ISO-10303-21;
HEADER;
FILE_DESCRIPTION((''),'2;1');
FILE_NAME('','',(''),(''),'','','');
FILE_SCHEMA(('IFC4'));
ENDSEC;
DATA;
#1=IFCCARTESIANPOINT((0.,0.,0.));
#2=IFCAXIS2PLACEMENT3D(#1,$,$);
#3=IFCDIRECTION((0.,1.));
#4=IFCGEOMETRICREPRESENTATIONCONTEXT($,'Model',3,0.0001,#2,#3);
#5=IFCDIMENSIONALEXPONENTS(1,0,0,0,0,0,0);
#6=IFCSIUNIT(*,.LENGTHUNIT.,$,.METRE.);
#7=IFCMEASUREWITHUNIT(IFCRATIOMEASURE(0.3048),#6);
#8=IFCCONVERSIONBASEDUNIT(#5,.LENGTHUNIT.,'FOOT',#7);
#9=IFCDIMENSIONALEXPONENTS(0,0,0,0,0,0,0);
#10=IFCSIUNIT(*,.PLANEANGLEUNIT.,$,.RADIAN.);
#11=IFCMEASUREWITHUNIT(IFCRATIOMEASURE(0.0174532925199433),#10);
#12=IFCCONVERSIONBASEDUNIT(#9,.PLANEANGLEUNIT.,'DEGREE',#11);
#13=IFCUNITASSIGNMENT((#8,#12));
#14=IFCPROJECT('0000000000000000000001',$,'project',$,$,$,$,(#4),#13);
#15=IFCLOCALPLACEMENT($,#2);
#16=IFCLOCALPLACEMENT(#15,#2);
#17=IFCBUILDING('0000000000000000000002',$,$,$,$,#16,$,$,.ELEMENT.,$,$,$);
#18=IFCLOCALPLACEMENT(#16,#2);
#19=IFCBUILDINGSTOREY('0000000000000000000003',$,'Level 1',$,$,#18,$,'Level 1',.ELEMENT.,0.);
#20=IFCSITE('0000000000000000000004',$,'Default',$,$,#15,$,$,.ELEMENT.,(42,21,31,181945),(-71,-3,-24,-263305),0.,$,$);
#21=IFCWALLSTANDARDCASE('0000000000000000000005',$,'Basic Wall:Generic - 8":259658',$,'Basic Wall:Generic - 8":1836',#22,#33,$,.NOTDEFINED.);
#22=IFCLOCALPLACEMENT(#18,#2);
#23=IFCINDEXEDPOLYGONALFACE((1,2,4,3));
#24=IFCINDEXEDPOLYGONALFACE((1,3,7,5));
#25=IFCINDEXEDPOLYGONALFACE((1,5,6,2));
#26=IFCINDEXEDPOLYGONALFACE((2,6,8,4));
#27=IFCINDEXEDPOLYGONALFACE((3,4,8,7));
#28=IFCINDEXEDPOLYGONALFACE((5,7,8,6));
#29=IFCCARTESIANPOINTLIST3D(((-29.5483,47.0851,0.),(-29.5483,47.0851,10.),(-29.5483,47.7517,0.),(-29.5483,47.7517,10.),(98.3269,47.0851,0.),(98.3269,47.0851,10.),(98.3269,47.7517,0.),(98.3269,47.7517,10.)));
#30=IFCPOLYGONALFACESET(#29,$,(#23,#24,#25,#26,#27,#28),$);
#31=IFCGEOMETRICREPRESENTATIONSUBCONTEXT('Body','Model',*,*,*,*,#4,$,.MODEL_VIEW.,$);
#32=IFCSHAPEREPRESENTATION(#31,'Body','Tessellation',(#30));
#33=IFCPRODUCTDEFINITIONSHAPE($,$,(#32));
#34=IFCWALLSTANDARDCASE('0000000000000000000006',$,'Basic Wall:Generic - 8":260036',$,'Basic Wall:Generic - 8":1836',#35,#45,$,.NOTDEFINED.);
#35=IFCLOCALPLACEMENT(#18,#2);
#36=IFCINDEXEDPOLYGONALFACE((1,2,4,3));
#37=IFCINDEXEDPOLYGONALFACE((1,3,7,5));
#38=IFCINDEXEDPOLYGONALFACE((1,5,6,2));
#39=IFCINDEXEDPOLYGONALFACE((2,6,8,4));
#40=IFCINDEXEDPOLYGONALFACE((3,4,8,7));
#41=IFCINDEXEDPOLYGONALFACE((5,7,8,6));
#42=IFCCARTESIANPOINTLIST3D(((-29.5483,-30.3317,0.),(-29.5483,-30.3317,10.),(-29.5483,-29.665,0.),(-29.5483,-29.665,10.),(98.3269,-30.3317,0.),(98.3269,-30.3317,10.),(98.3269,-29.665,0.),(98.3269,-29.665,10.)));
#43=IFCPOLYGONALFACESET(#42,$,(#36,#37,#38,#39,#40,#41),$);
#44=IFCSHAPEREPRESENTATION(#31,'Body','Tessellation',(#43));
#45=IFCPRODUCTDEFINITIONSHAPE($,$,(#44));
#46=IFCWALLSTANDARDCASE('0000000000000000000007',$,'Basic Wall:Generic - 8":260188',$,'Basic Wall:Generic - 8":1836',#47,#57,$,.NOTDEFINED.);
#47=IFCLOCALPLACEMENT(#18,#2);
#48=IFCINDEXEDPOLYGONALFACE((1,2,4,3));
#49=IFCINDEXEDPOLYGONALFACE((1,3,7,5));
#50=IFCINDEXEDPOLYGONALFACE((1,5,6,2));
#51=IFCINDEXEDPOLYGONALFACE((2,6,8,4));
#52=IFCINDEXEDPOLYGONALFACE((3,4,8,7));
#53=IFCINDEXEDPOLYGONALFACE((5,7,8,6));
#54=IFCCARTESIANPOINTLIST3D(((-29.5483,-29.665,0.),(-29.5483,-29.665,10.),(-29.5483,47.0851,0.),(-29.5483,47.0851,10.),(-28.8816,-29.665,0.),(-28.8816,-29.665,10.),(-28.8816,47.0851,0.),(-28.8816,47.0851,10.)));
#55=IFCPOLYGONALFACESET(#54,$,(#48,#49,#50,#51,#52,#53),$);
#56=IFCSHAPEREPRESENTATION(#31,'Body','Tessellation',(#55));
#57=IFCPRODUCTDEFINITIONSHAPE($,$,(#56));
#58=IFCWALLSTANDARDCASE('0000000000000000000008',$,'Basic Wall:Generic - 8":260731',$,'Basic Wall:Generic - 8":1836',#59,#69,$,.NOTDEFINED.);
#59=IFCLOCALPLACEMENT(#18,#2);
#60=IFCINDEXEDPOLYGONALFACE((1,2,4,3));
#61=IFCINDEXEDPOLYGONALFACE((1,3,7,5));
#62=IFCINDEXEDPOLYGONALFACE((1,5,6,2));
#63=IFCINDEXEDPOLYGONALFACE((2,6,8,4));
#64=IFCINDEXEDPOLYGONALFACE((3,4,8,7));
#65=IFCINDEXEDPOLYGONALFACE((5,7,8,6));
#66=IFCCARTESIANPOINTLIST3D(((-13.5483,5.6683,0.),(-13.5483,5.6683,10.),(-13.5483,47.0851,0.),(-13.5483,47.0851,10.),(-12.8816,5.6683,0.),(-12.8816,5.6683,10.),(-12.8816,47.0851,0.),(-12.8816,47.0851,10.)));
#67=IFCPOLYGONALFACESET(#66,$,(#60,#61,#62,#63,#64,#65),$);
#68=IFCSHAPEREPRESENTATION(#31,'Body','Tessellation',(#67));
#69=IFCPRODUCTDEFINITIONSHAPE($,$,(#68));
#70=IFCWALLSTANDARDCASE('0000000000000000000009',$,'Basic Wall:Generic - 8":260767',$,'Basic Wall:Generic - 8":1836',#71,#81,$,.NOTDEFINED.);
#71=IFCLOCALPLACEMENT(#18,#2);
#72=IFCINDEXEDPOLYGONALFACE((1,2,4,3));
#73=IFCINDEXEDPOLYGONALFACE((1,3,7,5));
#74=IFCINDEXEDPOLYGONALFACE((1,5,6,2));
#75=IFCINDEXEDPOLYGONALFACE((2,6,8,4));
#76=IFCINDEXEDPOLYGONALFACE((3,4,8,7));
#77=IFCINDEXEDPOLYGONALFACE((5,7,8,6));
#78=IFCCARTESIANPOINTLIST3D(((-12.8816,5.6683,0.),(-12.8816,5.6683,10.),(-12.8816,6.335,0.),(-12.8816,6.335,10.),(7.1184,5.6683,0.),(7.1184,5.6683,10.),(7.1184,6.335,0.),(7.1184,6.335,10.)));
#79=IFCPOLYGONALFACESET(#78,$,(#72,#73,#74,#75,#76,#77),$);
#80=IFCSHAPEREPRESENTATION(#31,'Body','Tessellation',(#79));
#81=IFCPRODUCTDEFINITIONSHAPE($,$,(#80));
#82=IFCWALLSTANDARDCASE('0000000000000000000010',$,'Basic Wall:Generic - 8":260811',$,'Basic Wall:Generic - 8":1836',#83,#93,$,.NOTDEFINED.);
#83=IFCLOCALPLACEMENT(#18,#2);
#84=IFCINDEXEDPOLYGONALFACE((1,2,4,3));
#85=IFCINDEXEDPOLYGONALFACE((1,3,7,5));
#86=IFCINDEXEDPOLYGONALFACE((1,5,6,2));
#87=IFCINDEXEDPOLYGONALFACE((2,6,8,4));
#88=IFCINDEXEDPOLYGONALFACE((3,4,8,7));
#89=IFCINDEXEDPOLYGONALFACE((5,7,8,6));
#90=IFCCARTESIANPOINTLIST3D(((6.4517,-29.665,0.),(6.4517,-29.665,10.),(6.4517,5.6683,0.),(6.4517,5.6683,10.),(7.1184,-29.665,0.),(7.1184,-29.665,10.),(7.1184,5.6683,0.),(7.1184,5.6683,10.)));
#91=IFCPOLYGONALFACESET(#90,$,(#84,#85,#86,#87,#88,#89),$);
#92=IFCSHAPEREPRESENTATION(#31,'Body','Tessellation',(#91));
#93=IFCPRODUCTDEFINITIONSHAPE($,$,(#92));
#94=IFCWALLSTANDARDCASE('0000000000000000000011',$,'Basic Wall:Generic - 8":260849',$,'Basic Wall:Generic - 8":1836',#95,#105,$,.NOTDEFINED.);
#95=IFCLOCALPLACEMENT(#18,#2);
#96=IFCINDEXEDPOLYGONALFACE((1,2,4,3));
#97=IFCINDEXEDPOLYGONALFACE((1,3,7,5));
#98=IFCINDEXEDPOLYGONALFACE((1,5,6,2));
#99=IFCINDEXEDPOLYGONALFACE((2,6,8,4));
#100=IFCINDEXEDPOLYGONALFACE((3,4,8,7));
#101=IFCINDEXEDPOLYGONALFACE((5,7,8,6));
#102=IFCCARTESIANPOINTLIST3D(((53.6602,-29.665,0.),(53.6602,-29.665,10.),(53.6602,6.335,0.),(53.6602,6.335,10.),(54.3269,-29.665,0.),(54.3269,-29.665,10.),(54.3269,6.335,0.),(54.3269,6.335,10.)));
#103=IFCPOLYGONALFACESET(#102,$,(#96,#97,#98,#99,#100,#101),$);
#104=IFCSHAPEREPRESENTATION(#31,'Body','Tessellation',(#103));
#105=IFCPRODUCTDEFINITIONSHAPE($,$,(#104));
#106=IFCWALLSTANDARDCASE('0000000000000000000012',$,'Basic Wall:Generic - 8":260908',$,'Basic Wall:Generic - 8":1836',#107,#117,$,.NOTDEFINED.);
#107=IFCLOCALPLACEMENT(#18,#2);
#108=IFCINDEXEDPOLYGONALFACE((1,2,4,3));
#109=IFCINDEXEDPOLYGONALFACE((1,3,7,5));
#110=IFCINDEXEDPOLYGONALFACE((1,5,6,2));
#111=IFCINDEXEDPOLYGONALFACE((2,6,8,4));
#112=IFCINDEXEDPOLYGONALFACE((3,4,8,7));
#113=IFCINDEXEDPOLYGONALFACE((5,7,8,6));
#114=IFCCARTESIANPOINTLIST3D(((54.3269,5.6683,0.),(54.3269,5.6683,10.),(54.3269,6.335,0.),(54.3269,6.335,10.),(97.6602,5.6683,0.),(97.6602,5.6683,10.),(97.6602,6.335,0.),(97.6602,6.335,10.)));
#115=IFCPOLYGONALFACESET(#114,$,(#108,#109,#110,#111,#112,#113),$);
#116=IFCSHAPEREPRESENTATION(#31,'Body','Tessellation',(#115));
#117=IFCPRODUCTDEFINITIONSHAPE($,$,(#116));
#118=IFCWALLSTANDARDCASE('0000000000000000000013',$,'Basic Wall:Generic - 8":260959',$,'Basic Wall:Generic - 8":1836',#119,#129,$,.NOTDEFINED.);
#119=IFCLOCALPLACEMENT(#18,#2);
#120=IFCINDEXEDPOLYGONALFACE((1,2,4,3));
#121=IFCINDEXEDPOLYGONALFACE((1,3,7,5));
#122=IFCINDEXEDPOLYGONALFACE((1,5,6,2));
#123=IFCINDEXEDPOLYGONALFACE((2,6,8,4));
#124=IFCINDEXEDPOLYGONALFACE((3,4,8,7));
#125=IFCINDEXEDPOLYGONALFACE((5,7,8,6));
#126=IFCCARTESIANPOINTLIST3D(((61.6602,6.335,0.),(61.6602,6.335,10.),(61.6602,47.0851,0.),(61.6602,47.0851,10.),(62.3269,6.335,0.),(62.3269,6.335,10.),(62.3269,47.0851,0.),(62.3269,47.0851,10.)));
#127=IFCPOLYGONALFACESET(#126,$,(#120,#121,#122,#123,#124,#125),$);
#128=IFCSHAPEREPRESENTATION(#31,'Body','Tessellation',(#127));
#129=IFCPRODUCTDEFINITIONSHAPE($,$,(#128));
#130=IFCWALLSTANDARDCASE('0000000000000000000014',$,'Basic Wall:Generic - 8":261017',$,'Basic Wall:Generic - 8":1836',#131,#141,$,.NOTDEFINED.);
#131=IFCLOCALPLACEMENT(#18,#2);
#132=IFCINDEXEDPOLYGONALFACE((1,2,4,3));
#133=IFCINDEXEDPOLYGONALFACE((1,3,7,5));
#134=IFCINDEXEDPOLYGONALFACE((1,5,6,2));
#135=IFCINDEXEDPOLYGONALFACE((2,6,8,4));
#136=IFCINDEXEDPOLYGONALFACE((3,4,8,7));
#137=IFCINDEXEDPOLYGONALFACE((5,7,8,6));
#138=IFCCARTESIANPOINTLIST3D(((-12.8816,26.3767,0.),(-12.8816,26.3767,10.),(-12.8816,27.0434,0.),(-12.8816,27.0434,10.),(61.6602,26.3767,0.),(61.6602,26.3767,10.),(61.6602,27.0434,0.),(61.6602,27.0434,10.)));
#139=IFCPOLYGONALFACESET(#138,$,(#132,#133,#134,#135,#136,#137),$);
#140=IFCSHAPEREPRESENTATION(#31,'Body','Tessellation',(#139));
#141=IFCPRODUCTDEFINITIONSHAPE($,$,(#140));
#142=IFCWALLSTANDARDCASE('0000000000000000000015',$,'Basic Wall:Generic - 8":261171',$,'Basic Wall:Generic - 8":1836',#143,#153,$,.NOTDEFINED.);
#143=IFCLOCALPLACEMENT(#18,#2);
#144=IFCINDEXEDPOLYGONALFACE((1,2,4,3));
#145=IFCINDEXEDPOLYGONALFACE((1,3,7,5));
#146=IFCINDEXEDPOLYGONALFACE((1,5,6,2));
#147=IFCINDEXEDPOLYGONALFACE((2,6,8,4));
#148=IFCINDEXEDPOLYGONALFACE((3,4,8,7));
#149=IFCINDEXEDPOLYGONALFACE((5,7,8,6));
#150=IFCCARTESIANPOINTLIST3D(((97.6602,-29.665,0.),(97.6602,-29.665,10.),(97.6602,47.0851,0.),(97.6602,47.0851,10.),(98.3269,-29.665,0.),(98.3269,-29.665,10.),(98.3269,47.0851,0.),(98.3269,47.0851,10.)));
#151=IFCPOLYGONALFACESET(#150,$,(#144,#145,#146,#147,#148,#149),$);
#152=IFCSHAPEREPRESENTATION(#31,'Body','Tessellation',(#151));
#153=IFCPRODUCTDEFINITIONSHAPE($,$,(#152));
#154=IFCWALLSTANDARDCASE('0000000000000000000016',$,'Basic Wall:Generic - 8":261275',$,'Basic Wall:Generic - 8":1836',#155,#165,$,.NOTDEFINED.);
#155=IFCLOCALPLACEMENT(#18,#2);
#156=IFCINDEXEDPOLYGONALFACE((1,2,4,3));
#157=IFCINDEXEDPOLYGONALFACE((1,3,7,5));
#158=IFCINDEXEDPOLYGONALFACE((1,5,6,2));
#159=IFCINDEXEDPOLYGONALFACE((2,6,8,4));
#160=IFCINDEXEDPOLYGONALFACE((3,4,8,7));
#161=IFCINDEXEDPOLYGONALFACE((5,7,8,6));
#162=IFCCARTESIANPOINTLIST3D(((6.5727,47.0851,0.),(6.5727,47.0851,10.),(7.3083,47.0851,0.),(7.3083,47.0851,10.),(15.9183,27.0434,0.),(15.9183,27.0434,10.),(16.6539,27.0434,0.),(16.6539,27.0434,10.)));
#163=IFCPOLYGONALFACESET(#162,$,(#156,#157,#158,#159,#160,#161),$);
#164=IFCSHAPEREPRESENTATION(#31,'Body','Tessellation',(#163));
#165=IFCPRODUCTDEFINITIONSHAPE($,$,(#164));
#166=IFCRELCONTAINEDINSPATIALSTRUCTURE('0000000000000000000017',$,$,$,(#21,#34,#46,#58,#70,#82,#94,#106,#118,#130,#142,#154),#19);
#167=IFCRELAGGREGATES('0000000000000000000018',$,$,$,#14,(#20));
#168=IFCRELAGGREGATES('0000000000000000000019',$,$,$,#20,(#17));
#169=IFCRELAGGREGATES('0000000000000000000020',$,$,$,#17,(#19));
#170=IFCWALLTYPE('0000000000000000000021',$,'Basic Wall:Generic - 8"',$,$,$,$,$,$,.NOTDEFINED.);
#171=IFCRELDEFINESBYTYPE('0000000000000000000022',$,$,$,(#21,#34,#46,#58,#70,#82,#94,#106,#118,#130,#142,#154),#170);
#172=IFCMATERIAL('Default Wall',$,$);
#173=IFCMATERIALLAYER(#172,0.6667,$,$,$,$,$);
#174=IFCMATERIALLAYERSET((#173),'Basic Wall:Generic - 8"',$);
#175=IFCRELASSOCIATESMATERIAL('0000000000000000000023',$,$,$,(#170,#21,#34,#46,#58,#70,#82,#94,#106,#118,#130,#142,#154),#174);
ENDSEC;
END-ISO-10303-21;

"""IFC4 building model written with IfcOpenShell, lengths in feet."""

from ifc_helpers import new_model, entity, si_unit, converted_unit, direction, frame, frame_2d, origin, place, context, subcontext, project, spatial, polyline, rectangle, outline, extrude, material, layer, layer_set, layer_usage, type_object, element, save


model = new_model("IFC4")

# Units and contexts
model_context = context("Model", 3, precision=0.0001, world=origin(), true_north=direction((0.0, 1.0)))
body_context = subcontext(model_context, "Body", "Model", "MODEL_VIEW")
ifc_project = project(units=[converted_unit("LENGTHUNIT", "FOOT", entity("IfcRatioMeasure", 0.3048), si_unit("LENGTHUNIT", "METRE"), dimensions=[1, 0, 0, 0, 0, 0, 0]), converted_unit("PLANEANGLEUNIT", "DEGREE", entity("IfcRatioMeasure", 0.0174532925199433), si_unit("PLANEANGLEUNIT", "RADIAN"), dimensions=[0, 0, 0, 0, 0, 0, 0])], contexts=[model_context])

# Site, building, storey
site_placement = place(None, origin())
site = spatial("IfcSite", under=ifc_project, at=site_placement, Name="Default", CompositionType="ELEMENT", RefLatitude=(42, 21, 31, 181945), RefLongitude=(-71, -3, -24, -263305), RefElevation=0.0)
building_placement = place(site_placement, origin())
building = spatial("IfcBuilding", under=site, at=building_placement, CompositionType="ELEMENT")
storey_placement = place(building_placement, origin())
storey = spatial("IfcBuildingStorey", under=building, at=storey_placement, Name="Level 1", LongName="Level 1", CompositionType="ELEMENT", Elevation=0.0)

# Walls
ifc_material = material(Name="Default Wall")
ifc_layer = layer(ifc_material, 0.6667)
ifc_layer_set = layer_set([ifc_layer], Name="Basic Wall:Generic - 8\"")
ifc_layer_usage_1 = layer_usage(ifc_layer_set, "AXIS2", "NEGATIVE", 0.3333)
wall_type = type_object("IfcWallType", Name="Basic Wall:Generic - 8\"", PredefinedType="NOTDEFINED", material=ifc_layer_set)
wall_1_placement = place(storey_placement, frame((-29.5483, 47.4184, 0.0)))
element("IfcWallStandardCase", 1, at=wall_1_placement, inside=storey, type_object=wall_type, material=ifc_layer_usage_1, Name="Basic Wall:Generic - 8\":259658", ObjectType="Basic Wall:Generic - 8\":1836", PredefinedType="NOTDEFINED", context=body_context, shape_type="SweptSolid", body=[
    extrude(rectangle(XDim=127.8752, YDim=0.6667, at=frame_2d((63.9376, 0.0), x_axis=(-1.0, 0.0))), origin(), (0.0, 0.0, 1.0), 10.0),
])
ifc_layer_usage_2 = layer_usage(ifc_layer_set, "AXIS2", "NEGATIVE", 0.3333)
wall_2_placement = place(storey_placement, frame((98.3269, -29.9983, 0.0), z_axis=(0.0, 0.0, 1.0), x_axis=(-1.0, 0.0, 0.0)))
element("IfcWallStandardCase", 2, at=wall_2_placement, inside=storey, type_object=wall_type, material=ifc_layer_usage_2, Name="Basic Wall:Generic - 8\":260036", ObjectType="Basic Wall:Generic - 8\":1836", PredefinedType="NOTDEFINED", context=body_context, shape_type="SweptSolid", body=[
    extrude(rectangle(XDim=127.8752, YDim=0.6667, at=frame_2d((63.9376, 0.0), x_axis=(-1.0, 0.0))), origin(), (0.0, 0.0, 1.0), 10.0),
])
ifc_layer_usage_3 = layer_usage(ifc_layer_set, "AXIS2", "NEGATIVE", 0.3333)
wall_3_placement = place(storey_placement, frame((-29.215, 47.0851, 0.0), z_axis=(0.0, 0.0, 1.0), x_axis=(0.0, -1.0, 0.0)))
element("IfcWallStandardCase", 3, at=wall_3_placement, inside=storey, type_object=wall_type, material=ifc_layer_usage_3, Name="Basic Wall:Generic - 8\":260188", ObjectType="Basic Wall:Generic - 8\":1836", PredefinedType="NOTDEFINED", context=body_context, shape_type="SweptSolid", body=[
    extrude(rectangle(XDim=76.7501, YDim=0.6667, at=frame_2d((38.375, 0.0), x_axis=(-1.0, 0.0))), origin(), (0.0, 0.0, 1.0), 10.0),
])
ifc_layer_usage_4 = layer_usage(ifc_layer_set, "AXIS2", "NEGATIVE", 0.3333)
wall_4_placement = place(storey_placement, frame((-13.215, 47.0851, 0.0), z_axis=(0.0, 0.0, 1.0), x_axis=(0.0, -1.0, 0.0)))
element("IfcWallStandardCase", 4, at=wall_4_placement, inside=storey, type_object=wall_type, material=ifc_layer_usage_4, Name="Basic Wall:Generic - 8\":260731", ObjectType="Basic Wall:Generic - 8\":1836", PredefinedType="NOTDEFINED", context=body_context, shape_type="SweptSolid", body=[
    extrude(rectangle(XDim=41.4167, YDim=0.6667, at=frame_2d((20.7084, 0.0), x_axis=(-1.0, 0.0))), origin(), (0.0, 0.0, 1.0), 10.0),
])
ifc_layer_usage_5 = layer_usage(ifc_layer_set, "AXIS2", "NEGATIVE", 0.3333)
wall_5_placement = place(storey_placement, frame((-12.8816, 6.0017, 0.0)))
element("IfcWallStandardCase", 5, at=wall_5_placement, inside=storey, type_object=wall_type, material=ifc_layer_usage_5, Name="Basic Wall:Generic - 8\":260767", ObjectType="Basic Wall:Generic - 8\":1836", PredefinedType="NOTDEFINED", context=body_context, shape_type="SweptSolid", body=[
    extrude(rectangle(XDim=20.0, YDim=0.6667, at=frame_2d((10.0, 0.0), x_axis=(-1.0, 0.0))), origin(), (0.0, 0.0, 1.0), 10.0),
])
ifc_layer_usage_6 = layer_usage(ifc_layer_set, "AXIS2", "NEGATIVE", 0.3333)
wall_6_placement = place(storey_placement, frame((6.785, 5.6683, 0.0), z_axis=(0.0, 0.0, 1.0), x_axis=(0.0, -1.0, 0.0)))
element("IfcWallStandardCase", 6, at=wall_6_placement, inside=storey, type_object=wall_type, material=ifc_layer_usage_6, Name="Basic Wall:Generic - 8\":260811", ObjectType="Basic Wall:Generic - 8\":1836", PredefinedType="NOTDEFINED", context=body_context, shape_type="SweptSolid", body=[
    extrude(rectangle(XDim=35.3333, YDim=0.6667, at=frame_2d((17.6667, 0.0), x_axis=(-1.0, 0.0))), origin(), (0.0, 0.0, 1.0), 10.0),
])
ifc_layer_usage_7 = layer_usage(ifc_layer_set, "AXIS2", "NEGATIVE", 0.3333)
wall_7_placement = place(storey_placement, frame((53.9936, 6.335, 0.0), z_axis=(0.0, 0.0, 1.0), x_axis=(0.0, -1.0, 0.0)))
element("IfcWallStandardCase", 7, at=wall_7_placement, inside=storey, type_object=wall_type, material=ifc_layer_usage_7, Name="Basic Wall:Generic - 8\":260849", ObjectType="Basic Wall:Generic - 8\":1836", PredefinedType="NOTDEFINED", context=body_context, shape_type="SweptSolid", body=[
    extrude(rectangle(XDim=36.0, YDim=0.6667, at=frame_2d((18.0, 0.0), x_axis=(-1.0, 0.0))), origin(), (0.0, 0.0, 1.0), 10.0),
])
ifc_layer_usage_8 = layer_usage(ifc_layer_set, "AXIS2", "NEGATIVE", 0.3333)
wall_8_placement = place(storey_placement, frame((54.3269, 6.0017, 0.0)))
element("IfcWallStandardCase", 8, at=wall_8_placement, inside=storey, type_object=wall_type, material=ifc_layer_usage_8, Name="Basic Wall:Generic - 8\":260908", ObjectType="Basic Wall:Generic - 8\":1836", PredefinedType="NOTDEFINED", context=body_context, shape_type="SweptSolid", body=[
    extrude(rectangle(XDim=43.3333, YDim=0.6667, at=frame_2d((21.6667, 0.0), x_axis=(-1.0, 0.0))), origin(), (0.0, 0.0, 1.0), 10.0),
])
ifc_layer_usage_9 = layer_usage(ifc_layer_set, "AXIS2", "NEGATIVE", 0.3333)
wall_9_placement = place(storey_placement, frame((61.9936, 47.0851, 0.0), z_axis=(0.0, 0.0, 1.0), x_axis=(0.0, -1.0, 0.0)))
element("IfcWallStandardCase", 9, at=wall_9_placement, inside=storey, type_object=wall_type, material=ifc_layer_usage_9, Name="Basic Wall:Generic - 8\":260959", ObjectType="Basic Wall:Generic - 8\":1836", PredefinedType="NOTDEFINED", context=body_context, shape_type="SweptSolid", body=[
    extrude(rectangle(XDim=40.7501, YDim=0.6667, at=frame_2d((20.375, 0.0), x_axis=(-1.0, 0.0))), origin(), (0.0, 0.0, 1.0), 10.0),
])
ifc_layer_usage_10 = layer_usage(ifc_layer_set, "AXIS2", "NEGATIVE", 0.3333)
wall_10_placement = place(storey_placement, frame((-12.8816, 26.71, 0.0)))
element("IfcWallStandardCase", 10, at=wall_10_placement, inside=storey, type_object=wall_type, material=ifc_layer_usage_10, Name="Basic Wall:Generic - 8\":261017", ObjectType="Basic Wall:Generic - 8\":1836", PredefinedType="NOTDEFINED", context=body_context, shape_type="SweptSolid", body=[
    extrude(rectangle(XDim=74.5419, YDim=0.6667, at=frame_2d((37.2709, 0.0), x_axis=(-1.0, 0.0))), origin(), (0.0, 0.0, 1.0), 10.0),
])
ifc_layer_usage_11 = layer_usage(ifc_layer_set, "AXIS2", "NEGATIVE", 0.3333)
wall_11_placement = place(storey_placement, frame((97.9936, 47.0851, 0.0), z_axis=(0.0, 0.0, 1.0), x_axis=(0.0, -1.0, 0.0)))
element("IfcWallStandardCase", 11, at=wall_11_placement, inside=storey, type_object=wall_type, material=ifc_layer_usage_11, Name="Basic Wall:Generic - 8\":261171", ObjectType="Basic Wall:Generic - 8\":1836", PredefinedType="NOTDEFINED", context=body_context, shape_type="SweptSolid", body=[
    extrude(rectangle(XDim=76.7501, YDim=0.6667, at=frame_2d((38.375, 0.0), x_axis=(-1.0, 0.0))), origin(), (0.0, 0.0, 1.0), 10.0),
])
ifc_layer_usage_12 = layer_usage(ifc_layer_set, "AXIS2", "NEGATIVE", 0.3333)
wall_12_placement = place(storey_placement, frame((6.8748, 47.226, 0.0), z_axis=(0.0, 0.0, 1.0), x_axis=(0.422618, -0.906308, 0.0)))
element("IfcWallStandardCase", 12, at=wall_12_placement, inside=storey, type_object=wall_type, material=ifc_layer_usage_12, Name="Basic Wall:Generic - 8\":261275", ObjectType="Basic Wall:Generic - 8\":1836", PredefinedType="NOTDEFINED", context=body_context, shape_type="SweptSolid", body=[
    extrude(outline(polyline([(22.1136, -0.3333), (22.4244, 0.3333), (0.3109, 0.3333), (0.0, -0.3333), (22.1136, -0.3333)])), origin(), (0.0, 0.0, 1.0), 10.0),
])

save(model, "model.ifc")
